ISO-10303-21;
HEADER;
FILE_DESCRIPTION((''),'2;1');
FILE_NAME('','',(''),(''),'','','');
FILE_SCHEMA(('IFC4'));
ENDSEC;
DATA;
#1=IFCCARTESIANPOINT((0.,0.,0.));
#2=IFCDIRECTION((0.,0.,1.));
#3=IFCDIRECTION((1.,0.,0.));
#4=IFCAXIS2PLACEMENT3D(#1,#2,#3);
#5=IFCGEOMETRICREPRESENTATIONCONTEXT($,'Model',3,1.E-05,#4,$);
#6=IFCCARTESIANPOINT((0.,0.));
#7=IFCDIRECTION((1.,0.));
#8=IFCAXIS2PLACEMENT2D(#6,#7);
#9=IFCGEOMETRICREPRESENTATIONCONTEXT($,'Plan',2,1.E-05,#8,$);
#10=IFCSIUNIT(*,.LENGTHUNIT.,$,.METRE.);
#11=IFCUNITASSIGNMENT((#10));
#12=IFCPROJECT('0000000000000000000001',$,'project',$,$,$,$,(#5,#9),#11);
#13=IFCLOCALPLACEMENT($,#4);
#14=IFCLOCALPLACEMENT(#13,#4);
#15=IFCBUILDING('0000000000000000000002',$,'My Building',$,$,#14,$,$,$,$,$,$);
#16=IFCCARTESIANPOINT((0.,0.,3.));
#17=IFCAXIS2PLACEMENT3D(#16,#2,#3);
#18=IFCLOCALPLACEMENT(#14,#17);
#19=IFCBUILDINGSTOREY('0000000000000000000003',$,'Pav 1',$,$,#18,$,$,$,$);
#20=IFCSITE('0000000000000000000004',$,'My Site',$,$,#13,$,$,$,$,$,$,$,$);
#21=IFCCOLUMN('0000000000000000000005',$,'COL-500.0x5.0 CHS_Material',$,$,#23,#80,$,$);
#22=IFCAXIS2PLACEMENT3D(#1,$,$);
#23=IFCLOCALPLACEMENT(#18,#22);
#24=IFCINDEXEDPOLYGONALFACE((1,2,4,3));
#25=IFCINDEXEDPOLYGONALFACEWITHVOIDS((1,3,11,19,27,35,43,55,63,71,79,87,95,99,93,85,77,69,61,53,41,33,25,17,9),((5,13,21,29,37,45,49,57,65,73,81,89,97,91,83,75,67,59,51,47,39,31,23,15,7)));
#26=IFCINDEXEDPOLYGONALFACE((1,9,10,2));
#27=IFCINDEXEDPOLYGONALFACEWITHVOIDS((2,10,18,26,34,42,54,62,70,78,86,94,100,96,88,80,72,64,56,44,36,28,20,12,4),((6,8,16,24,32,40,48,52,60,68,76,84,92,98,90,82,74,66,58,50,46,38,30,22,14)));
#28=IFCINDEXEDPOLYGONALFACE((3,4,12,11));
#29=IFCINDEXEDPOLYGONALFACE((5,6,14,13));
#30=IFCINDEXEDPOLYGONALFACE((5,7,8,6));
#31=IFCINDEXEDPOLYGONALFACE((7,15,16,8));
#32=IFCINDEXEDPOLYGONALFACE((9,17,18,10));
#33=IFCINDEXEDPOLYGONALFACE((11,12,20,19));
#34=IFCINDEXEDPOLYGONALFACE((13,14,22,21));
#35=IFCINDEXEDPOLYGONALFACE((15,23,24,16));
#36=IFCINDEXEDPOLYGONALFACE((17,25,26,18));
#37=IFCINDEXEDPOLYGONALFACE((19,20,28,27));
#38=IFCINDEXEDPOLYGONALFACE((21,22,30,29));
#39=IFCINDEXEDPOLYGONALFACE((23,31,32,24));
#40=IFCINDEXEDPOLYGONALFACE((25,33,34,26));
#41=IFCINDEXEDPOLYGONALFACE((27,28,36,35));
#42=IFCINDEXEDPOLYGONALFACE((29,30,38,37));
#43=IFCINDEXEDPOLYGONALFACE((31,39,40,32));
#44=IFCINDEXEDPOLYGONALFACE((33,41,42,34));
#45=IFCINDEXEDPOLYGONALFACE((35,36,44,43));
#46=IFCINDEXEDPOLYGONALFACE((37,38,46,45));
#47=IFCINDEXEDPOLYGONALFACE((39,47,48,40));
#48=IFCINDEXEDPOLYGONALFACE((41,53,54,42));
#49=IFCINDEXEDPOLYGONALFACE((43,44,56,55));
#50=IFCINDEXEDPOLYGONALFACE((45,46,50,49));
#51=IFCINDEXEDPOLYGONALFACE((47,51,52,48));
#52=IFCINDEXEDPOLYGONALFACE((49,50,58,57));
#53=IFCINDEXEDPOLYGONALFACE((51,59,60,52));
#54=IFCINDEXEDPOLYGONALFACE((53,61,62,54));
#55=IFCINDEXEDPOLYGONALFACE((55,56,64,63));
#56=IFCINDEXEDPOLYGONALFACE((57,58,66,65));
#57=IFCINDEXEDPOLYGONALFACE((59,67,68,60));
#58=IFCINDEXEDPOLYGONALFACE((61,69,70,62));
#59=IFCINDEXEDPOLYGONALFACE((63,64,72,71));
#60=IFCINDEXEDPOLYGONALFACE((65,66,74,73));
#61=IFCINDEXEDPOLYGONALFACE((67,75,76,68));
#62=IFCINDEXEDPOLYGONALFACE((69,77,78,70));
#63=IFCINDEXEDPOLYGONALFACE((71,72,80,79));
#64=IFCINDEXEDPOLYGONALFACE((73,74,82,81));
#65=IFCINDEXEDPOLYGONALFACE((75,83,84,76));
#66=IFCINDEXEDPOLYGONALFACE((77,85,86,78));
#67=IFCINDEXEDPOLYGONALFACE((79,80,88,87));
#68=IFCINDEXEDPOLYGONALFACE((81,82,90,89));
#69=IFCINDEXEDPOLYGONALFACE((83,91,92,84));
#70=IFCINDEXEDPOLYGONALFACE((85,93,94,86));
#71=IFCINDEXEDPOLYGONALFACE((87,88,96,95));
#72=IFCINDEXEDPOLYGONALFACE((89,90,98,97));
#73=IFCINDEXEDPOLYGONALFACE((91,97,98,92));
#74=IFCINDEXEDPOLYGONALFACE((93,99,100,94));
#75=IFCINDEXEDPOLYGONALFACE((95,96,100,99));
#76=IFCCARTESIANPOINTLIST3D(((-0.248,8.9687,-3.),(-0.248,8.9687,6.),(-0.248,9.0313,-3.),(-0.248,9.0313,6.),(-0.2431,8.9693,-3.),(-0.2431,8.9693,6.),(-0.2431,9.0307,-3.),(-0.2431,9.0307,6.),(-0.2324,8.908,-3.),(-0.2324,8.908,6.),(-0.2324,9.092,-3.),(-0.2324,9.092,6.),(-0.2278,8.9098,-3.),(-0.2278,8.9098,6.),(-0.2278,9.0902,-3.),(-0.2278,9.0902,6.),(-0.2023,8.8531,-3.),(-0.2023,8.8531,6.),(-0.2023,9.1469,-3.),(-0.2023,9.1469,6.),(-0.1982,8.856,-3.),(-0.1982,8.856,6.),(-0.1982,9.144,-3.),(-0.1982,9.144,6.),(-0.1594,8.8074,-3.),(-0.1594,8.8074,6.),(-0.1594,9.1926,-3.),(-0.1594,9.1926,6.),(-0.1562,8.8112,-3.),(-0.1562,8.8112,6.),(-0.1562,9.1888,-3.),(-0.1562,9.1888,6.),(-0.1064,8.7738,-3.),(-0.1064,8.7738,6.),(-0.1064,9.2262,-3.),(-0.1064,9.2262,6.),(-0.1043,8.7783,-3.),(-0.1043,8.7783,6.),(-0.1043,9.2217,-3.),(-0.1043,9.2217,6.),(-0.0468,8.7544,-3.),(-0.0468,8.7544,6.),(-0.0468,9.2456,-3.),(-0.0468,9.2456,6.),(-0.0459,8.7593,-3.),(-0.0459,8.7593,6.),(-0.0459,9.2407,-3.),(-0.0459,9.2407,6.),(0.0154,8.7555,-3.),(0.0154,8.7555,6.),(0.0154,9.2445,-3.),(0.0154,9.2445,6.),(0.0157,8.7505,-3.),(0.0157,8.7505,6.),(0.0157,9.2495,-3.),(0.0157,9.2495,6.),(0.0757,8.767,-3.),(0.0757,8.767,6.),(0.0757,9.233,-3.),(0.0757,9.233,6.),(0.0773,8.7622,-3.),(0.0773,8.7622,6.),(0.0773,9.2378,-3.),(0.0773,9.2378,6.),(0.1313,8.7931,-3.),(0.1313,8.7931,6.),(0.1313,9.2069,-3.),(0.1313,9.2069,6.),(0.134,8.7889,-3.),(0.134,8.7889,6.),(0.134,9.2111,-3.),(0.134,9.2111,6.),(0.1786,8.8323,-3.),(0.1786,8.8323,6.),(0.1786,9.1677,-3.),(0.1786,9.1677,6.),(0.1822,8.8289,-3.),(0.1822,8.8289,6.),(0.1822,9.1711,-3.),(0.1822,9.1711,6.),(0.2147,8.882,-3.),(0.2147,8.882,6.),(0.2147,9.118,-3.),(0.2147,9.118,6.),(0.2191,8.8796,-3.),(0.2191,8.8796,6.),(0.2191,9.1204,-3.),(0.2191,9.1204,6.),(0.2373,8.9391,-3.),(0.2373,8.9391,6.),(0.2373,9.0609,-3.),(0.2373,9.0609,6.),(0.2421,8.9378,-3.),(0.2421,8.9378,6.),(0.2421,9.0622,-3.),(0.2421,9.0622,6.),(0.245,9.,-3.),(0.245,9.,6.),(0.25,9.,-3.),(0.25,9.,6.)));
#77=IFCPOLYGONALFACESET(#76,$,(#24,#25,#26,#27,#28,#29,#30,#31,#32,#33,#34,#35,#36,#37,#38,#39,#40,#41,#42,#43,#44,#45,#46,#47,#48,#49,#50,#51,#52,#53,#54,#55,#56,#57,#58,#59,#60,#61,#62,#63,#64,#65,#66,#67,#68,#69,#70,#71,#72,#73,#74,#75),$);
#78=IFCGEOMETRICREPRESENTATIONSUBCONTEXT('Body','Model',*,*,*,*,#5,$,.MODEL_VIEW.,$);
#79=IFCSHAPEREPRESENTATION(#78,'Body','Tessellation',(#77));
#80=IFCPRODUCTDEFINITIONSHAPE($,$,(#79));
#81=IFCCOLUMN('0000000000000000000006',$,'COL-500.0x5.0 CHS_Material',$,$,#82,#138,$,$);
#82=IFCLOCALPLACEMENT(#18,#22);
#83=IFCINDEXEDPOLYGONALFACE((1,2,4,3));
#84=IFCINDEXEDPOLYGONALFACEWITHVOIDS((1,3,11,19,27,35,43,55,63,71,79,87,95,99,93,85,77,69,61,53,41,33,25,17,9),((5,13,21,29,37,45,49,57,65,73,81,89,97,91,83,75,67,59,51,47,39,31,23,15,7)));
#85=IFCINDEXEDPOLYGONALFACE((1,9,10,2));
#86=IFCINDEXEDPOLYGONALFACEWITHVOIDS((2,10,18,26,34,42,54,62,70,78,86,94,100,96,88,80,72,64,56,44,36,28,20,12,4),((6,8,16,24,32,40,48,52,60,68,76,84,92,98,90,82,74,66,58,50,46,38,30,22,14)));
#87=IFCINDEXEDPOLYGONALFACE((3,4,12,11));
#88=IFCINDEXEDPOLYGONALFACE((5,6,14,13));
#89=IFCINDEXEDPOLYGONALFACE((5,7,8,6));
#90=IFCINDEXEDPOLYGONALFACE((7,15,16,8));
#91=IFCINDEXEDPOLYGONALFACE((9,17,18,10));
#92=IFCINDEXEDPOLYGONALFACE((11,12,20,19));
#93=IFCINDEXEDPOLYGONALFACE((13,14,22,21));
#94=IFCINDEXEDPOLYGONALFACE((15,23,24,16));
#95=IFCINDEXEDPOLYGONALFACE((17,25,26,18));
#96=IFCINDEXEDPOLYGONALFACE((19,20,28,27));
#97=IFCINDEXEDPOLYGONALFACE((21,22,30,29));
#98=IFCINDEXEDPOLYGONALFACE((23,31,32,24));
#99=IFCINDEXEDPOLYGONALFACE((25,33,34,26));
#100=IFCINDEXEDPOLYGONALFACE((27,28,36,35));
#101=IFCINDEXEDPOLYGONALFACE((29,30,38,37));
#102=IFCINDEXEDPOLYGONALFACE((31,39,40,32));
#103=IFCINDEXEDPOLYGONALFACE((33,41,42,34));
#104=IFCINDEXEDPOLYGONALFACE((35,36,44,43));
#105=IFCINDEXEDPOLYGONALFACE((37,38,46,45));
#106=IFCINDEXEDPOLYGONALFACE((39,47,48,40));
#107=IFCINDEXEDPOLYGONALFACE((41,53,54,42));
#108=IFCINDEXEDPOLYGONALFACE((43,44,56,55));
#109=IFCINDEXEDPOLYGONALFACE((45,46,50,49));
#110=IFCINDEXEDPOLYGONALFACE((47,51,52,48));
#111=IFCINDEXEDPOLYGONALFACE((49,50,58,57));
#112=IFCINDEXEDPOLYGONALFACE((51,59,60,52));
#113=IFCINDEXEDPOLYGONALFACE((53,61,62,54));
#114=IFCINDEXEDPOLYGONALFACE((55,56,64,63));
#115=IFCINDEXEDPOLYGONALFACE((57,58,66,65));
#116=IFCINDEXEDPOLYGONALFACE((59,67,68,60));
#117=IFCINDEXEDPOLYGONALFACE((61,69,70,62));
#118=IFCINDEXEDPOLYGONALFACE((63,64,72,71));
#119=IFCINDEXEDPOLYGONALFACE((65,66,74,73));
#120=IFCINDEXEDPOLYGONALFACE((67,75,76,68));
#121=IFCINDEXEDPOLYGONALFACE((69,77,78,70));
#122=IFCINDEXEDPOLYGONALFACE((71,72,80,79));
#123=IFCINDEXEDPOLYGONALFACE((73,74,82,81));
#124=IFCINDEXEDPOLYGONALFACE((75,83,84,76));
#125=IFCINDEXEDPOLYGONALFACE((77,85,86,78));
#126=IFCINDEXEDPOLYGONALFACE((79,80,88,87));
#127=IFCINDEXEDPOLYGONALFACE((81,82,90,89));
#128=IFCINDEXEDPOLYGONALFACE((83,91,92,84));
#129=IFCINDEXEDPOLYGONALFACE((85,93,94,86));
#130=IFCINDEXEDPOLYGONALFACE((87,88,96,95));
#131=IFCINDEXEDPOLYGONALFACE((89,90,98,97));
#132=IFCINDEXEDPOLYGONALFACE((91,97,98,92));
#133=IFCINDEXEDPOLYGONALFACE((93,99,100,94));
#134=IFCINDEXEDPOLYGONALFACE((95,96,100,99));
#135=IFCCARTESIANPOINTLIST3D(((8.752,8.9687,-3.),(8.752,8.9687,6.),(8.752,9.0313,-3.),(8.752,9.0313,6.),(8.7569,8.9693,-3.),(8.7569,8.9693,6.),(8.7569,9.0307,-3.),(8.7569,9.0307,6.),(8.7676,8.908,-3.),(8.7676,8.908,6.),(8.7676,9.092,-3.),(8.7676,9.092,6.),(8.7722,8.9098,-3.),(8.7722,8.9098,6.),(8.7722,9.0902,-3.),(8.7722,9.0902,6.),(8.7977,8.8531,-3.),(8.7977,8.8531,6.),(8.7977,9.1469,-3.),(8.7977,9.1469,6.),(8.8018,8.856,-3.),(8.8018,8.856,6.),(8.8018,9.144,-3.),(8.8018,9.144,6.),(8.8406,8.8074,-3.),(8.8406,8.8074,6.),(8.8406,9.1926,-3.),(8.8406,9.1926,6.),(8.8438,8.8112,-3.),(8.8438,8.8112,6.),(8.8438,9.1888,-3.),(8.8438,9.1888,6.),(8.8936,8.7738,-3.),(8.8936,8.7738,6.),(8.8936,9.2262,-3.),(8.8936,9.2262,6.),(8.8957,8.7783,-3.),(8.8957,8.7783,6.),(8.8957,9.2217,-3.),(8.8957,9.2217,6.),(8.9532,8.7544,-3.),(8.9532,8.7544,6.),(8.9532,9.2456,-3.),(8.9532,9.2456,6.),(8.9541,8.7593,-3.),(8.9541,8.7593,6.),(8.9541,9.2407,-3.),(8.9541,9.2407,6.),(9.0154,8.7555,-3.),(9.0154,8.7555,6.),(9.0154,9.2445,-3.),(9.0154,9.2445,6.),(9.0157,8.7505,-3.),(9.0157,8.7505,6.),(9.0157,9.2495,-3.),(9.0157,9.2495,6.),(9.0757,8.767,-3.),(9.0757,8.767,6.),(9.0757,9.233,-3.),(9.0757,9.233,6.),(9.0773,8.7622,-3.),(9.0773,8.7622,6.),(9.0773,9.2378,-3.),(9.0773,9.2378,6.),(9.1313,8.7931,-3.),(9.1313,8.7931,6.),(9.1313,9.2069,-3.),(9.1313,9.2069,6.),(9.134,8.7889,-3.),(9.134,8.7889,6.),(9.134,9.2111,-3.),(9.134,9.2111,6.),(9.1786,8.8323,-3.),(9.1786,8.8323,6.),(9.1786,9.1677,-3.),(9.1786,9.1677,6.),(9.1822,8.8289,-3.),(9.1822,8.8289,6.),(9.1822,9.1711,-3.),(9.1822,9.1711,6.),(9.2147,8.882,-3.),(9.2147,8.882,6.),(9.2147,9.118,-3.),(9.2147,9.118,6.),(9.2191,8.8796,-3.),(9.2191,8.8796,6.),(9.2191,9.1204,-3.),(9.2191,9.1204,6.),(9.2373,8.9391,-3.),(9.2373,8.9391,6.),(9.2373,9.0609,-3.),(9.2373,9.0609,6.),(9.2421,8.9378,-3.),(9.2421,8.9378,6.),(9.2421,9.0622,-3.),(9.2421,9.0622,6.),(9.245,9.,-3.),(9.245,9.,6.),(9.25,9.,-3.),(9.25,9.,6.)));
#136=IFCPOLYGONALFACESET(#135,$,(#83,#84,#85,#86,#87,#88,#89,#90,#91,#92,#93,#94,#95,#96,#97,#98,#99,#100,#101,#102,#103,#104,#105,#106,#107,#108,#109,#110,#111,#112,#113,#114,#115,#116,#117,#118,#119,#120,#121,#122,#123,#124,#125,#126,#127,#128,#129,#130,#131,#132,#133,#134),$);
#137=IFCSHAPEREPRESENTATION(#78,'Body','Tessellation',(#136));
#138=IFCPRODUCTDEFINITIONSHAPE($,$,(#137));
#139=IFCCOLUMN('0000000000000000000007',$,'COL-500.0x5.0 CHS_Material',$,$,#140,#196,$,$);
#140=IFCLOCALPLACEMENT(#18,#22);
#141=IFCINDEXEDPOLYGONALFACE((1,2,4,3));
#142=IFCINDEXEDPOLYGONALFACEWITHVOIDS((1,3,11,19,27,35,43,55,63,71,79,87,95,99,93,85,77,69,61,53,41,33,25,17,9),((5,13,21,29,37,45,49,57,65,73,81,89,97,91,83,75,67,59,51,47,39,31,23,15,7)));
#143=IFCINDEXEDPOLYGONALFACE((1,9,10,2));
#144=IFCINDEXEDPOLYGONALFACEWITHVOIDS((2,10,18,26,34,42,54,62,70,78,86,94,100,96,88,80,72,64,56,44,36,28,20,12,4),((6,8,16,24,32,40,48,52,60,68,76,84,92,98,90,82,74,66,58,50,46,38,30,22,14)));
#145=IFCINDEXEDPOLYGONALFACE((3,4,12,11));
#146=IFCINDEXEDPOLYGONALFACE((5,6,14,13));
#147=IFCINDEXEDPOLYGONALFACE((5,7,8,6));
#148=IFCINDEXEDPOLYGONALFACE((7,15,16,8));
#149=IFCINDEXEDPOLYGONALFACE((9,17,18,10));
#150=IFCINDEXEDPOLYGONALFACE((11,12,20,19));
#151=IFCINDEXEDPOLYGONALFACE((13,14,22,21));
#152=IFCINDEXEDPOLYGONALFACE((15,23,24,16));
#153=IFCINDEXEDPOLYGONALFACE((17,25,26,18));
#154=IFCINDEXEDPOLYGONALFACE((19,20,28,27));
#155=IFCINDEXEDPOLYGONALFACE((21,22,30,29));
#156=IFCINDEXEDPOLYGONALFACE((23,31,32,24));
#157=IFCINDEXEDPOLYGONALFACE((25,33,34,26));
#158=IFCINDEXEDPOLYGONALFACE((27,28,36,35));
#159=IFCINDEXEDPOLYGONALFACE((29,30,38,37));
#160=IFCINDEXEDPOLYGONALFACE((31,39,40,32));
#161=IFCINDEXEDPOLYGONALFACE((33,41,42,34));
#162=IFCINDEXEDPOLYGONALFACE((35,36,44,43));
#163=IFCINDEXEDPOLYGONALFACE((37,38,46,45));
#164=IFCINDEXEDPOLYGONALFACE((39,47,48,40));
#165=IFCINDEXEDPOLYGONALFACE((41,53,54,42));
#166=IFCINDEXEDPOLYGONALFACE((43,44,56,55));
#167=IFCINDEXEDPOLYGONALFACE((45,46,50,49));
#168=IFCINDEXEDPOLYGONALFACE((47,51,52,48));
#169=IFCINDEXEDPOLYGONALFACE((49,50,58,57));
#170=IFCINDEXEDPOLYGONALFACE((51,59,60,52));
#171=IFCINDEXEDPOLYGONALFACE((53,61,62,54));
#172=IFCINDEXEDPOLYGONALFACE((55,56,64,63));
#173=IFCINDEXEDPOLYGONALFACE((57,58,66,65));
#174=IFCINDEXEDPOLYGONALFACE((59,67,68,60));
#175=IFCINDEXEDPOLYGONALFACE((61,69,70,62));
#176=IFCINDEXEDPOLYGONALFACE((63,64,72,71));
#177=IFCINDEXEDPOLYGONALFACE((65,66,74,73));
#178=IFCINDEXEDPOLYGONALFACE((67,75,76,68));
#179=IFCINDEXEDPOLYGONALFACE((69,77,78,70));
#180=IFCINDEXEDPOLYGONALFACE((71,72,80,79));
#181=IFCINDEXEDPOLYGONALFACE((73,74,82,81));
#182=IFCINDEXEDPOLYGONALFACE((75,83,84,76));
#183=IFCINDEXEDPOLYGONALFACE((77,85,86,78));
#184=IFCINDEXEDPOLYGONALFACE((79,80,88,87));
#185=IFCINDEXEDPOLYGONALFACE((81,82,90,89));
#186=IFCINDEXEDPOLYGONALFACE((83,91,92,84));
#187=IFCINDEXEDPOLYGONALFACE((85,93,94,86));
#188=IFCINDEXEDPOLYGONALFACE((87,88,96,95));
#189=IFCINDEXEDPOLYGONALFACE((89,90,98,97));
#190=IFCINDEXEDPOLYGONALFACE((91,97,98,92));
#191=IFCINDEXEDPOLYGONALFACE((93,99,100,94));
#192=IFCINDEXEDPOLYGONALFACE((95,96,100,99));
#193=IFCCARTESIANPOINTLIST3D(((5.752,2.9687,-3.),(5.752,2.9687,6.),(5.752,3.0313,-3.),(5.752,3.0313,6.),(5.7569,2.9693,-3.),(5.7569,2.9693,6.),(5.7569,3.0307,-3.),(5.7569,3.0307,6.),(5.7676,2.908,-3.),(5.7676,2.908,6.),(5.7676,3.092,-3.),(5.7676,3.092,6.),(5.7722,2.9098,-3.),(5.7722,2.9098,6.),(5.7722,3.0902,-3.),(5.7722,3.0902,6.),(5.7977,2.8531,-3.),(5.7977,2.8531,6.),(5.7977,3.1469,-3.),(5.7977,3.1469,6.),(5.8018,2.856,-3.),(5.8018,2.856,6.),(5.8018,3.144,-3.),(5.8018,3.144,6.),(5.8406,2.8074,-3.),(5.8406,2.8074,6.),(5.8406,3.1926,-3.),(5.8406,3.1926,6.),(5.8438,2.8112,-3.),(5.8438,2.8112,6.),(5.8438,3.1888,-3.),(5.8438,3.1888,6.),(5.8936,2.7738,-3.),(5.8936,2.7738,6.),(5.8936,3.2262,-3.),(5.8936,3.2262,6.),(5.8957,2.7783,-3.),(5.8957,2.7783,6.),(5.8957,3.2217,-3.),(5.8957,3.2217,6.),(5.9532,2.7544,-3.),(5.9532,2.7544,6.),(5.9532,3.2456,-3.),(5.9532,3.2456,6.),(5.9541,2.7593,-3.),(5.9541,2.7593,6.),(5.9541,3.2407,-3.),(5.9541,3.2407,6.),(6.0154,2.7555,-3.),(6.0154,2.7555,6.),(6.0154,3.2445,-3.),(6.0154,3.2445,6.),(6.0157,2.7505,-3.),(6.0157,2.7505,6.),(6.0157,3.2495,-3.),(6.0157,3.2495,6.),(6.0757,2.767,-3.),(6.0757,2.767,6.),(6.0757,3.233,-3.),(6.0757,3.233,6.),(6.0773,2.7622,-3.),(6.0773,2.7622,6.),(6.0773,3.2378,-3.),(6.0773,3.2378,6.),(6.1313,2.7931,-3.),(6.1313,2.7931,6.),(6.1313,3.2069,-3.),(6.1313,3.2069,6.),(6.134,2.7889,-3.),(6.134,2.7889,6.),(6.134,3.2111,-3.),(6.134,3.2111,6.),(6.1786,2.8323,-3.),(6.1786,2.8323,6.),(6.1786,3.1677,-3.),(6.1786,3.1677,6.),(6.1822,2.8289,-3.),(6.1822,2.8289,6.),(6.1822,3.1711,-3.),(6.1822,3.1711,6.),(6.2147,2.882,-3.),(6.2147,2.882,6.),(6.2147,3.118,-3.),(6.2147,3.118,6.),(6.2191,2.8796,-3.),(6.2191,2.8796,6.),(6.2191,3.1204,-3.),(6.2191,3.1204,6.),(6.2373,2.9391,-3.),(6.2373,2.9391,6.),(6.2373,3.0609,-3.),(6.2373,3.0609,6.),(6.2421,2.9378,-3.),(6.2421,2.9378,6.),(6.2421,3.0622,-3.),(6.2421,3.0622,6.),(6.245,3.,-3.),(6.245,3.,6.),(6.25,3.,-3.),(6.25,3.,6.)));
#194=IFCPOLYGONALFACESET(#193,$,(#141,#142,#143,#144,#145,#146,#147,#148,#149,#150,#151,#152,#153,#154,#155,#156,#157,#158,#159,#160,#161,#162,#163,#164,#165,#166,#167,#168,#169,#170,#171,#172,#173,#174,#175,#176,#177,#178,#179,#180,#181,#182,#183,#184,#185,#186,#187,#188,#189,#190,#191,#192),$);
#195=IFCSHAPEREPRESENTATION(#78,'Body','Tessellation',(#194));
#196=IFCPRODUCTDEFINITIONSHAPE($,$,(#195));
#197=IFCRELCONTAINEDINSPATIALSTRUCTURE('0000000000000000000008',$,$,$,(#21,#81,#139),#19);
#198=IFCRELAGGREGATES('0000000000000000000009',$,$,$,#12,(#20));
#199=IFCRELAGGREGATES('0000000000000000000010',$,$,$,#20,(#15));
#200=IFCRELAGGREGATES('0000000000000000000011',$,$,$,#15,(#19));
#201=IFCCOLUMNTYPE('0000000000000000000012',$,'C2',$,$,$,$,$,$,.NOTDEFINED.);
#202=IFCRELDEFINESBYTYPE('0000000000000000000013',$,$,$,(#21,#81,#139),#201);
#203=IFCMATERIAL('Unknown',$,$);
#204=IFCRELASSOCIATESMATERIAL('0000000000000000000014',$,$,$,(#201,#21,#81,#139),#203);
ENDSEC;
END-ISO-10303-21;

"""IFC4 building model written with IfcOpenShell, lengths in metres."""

from ifc_helpers import new_model, si_unit, frame, origin, origin_with_axes, origin_2d_with_axis, place, context, subcontext, project, spatial, hollow_circle, extrude, material, material_profile, profile_set, profile_usage, type_object, element, save


model = new_model("IFC4")

# Units and contexts
model_context = context("Model", 3, precision=1e-05, world=origin_with_axes())
plan_context = context("Plan", 2, precision=1e-05, world=origin_2d_with_axis())
body_context = subcontext(model_context, "Body", "Model", "MODEL_VIEW")
ifc_project = project(units=[si_unit("LENGTHUNIT", "METRE")], contexts=[model_context, plan_context])

# Site, building, storey
site_placement = place(None, origin_with_axes())
site = spatial("IfcSite", under=ifc_project, at=site_placement, Name="My Site")
building_placement = place(site_placement, origin_with_axes())
building = spatial("IfcBuilding", under=site, at=building_placement, Name="My Building")
storey_placement = place(building_placement, frame((0.0, 0.0, 3.0), z_axis=(0.0, 0.0, 1.0), x_axis=(1.0, 0.0, 0.0)))
storey = spatial("IfcBuildingStorey", under=building, at=storey_placement, Name="Pav 1")

# Columns
ifc_material = material(Name="Unknown")
ifc_material_profile = material_profile(ifc_material, hollow_circle(Radius=0.25, WallThickness=0.005))
ifc_profile_set = profile_set([ifc_material_profile])
column_type = type_object("IfcColumnType", Name="C2", PredefinedType="NOTDEFINED", material=ifc_profile_set)
ifc_profile_usage_1 = profile_usage(ifc_profile_set, cardinal=5)
column_1_placement = place(storey_placement, frame((0.0, 9.0, -3.0), z_axis=(0.0, 0.0, 1.0), x_axis=(1.0, 0.0, 0.0)))
element("IfcColumn", 1, at=column_1_placement, inside=storey, type_object=column_type, material=ifc_profile_usage_1, Name="COL-500.0x5.0 CHS_Material", context=body_context, shape_type="SweptSolid", body=[
    extrude(hollow_circle(Radius=0.25, WallThickness=0.005), origin(), (0.0, 0.0, 1.0), 9.0),
])
ifc_profile_usage_2 = profile_usage(ifc_profile_set, cardinal=5)
column_2_placement = place(storey_placement, frame((9.0, 9.0, -3.0), z_axis=(0.0, 0.0, 1.0), x_axis=(1.0, 0.0, 0.0)))
element("IfcColumn", 2, at=column_2_placement, inside=storey, type_object=column_type, material=ifc_profile_usage_2, Name="COL-500.0x5.0 CHS_Material", context=body_context, shape_type="SweptSolid", body=[
    extrude(hollow_circle(Radius=0.25, WallThickness=0.005), origin(), (0.0, 0.0, 1.0), 9.0),
])
ifc_profile_usage_3 = profile_usage(ifc_profile_set, cardinal=5)
column_3_placement = place(storey_placement, frame((6.0, 3.0, -3.0), z_axis=(0.0, 0.0, 1.0), x_axis=(1.0, 0.0, 0.0)))
element("IfcColumn", 3, at=column_3_placement, inside=storey, type_object=column_type, material=ifc_profile_usage_3, Name="COL-500.0x5.0 CHS_Material", context=body_context, shape_type="SweptSolid", body=[
    extrude(hollow_circle(Radius=0.25, WallThickness=0.005), origin(), (0.0, 0.0, 1.0), 9.0),
])

save(model, "model.ifc")
